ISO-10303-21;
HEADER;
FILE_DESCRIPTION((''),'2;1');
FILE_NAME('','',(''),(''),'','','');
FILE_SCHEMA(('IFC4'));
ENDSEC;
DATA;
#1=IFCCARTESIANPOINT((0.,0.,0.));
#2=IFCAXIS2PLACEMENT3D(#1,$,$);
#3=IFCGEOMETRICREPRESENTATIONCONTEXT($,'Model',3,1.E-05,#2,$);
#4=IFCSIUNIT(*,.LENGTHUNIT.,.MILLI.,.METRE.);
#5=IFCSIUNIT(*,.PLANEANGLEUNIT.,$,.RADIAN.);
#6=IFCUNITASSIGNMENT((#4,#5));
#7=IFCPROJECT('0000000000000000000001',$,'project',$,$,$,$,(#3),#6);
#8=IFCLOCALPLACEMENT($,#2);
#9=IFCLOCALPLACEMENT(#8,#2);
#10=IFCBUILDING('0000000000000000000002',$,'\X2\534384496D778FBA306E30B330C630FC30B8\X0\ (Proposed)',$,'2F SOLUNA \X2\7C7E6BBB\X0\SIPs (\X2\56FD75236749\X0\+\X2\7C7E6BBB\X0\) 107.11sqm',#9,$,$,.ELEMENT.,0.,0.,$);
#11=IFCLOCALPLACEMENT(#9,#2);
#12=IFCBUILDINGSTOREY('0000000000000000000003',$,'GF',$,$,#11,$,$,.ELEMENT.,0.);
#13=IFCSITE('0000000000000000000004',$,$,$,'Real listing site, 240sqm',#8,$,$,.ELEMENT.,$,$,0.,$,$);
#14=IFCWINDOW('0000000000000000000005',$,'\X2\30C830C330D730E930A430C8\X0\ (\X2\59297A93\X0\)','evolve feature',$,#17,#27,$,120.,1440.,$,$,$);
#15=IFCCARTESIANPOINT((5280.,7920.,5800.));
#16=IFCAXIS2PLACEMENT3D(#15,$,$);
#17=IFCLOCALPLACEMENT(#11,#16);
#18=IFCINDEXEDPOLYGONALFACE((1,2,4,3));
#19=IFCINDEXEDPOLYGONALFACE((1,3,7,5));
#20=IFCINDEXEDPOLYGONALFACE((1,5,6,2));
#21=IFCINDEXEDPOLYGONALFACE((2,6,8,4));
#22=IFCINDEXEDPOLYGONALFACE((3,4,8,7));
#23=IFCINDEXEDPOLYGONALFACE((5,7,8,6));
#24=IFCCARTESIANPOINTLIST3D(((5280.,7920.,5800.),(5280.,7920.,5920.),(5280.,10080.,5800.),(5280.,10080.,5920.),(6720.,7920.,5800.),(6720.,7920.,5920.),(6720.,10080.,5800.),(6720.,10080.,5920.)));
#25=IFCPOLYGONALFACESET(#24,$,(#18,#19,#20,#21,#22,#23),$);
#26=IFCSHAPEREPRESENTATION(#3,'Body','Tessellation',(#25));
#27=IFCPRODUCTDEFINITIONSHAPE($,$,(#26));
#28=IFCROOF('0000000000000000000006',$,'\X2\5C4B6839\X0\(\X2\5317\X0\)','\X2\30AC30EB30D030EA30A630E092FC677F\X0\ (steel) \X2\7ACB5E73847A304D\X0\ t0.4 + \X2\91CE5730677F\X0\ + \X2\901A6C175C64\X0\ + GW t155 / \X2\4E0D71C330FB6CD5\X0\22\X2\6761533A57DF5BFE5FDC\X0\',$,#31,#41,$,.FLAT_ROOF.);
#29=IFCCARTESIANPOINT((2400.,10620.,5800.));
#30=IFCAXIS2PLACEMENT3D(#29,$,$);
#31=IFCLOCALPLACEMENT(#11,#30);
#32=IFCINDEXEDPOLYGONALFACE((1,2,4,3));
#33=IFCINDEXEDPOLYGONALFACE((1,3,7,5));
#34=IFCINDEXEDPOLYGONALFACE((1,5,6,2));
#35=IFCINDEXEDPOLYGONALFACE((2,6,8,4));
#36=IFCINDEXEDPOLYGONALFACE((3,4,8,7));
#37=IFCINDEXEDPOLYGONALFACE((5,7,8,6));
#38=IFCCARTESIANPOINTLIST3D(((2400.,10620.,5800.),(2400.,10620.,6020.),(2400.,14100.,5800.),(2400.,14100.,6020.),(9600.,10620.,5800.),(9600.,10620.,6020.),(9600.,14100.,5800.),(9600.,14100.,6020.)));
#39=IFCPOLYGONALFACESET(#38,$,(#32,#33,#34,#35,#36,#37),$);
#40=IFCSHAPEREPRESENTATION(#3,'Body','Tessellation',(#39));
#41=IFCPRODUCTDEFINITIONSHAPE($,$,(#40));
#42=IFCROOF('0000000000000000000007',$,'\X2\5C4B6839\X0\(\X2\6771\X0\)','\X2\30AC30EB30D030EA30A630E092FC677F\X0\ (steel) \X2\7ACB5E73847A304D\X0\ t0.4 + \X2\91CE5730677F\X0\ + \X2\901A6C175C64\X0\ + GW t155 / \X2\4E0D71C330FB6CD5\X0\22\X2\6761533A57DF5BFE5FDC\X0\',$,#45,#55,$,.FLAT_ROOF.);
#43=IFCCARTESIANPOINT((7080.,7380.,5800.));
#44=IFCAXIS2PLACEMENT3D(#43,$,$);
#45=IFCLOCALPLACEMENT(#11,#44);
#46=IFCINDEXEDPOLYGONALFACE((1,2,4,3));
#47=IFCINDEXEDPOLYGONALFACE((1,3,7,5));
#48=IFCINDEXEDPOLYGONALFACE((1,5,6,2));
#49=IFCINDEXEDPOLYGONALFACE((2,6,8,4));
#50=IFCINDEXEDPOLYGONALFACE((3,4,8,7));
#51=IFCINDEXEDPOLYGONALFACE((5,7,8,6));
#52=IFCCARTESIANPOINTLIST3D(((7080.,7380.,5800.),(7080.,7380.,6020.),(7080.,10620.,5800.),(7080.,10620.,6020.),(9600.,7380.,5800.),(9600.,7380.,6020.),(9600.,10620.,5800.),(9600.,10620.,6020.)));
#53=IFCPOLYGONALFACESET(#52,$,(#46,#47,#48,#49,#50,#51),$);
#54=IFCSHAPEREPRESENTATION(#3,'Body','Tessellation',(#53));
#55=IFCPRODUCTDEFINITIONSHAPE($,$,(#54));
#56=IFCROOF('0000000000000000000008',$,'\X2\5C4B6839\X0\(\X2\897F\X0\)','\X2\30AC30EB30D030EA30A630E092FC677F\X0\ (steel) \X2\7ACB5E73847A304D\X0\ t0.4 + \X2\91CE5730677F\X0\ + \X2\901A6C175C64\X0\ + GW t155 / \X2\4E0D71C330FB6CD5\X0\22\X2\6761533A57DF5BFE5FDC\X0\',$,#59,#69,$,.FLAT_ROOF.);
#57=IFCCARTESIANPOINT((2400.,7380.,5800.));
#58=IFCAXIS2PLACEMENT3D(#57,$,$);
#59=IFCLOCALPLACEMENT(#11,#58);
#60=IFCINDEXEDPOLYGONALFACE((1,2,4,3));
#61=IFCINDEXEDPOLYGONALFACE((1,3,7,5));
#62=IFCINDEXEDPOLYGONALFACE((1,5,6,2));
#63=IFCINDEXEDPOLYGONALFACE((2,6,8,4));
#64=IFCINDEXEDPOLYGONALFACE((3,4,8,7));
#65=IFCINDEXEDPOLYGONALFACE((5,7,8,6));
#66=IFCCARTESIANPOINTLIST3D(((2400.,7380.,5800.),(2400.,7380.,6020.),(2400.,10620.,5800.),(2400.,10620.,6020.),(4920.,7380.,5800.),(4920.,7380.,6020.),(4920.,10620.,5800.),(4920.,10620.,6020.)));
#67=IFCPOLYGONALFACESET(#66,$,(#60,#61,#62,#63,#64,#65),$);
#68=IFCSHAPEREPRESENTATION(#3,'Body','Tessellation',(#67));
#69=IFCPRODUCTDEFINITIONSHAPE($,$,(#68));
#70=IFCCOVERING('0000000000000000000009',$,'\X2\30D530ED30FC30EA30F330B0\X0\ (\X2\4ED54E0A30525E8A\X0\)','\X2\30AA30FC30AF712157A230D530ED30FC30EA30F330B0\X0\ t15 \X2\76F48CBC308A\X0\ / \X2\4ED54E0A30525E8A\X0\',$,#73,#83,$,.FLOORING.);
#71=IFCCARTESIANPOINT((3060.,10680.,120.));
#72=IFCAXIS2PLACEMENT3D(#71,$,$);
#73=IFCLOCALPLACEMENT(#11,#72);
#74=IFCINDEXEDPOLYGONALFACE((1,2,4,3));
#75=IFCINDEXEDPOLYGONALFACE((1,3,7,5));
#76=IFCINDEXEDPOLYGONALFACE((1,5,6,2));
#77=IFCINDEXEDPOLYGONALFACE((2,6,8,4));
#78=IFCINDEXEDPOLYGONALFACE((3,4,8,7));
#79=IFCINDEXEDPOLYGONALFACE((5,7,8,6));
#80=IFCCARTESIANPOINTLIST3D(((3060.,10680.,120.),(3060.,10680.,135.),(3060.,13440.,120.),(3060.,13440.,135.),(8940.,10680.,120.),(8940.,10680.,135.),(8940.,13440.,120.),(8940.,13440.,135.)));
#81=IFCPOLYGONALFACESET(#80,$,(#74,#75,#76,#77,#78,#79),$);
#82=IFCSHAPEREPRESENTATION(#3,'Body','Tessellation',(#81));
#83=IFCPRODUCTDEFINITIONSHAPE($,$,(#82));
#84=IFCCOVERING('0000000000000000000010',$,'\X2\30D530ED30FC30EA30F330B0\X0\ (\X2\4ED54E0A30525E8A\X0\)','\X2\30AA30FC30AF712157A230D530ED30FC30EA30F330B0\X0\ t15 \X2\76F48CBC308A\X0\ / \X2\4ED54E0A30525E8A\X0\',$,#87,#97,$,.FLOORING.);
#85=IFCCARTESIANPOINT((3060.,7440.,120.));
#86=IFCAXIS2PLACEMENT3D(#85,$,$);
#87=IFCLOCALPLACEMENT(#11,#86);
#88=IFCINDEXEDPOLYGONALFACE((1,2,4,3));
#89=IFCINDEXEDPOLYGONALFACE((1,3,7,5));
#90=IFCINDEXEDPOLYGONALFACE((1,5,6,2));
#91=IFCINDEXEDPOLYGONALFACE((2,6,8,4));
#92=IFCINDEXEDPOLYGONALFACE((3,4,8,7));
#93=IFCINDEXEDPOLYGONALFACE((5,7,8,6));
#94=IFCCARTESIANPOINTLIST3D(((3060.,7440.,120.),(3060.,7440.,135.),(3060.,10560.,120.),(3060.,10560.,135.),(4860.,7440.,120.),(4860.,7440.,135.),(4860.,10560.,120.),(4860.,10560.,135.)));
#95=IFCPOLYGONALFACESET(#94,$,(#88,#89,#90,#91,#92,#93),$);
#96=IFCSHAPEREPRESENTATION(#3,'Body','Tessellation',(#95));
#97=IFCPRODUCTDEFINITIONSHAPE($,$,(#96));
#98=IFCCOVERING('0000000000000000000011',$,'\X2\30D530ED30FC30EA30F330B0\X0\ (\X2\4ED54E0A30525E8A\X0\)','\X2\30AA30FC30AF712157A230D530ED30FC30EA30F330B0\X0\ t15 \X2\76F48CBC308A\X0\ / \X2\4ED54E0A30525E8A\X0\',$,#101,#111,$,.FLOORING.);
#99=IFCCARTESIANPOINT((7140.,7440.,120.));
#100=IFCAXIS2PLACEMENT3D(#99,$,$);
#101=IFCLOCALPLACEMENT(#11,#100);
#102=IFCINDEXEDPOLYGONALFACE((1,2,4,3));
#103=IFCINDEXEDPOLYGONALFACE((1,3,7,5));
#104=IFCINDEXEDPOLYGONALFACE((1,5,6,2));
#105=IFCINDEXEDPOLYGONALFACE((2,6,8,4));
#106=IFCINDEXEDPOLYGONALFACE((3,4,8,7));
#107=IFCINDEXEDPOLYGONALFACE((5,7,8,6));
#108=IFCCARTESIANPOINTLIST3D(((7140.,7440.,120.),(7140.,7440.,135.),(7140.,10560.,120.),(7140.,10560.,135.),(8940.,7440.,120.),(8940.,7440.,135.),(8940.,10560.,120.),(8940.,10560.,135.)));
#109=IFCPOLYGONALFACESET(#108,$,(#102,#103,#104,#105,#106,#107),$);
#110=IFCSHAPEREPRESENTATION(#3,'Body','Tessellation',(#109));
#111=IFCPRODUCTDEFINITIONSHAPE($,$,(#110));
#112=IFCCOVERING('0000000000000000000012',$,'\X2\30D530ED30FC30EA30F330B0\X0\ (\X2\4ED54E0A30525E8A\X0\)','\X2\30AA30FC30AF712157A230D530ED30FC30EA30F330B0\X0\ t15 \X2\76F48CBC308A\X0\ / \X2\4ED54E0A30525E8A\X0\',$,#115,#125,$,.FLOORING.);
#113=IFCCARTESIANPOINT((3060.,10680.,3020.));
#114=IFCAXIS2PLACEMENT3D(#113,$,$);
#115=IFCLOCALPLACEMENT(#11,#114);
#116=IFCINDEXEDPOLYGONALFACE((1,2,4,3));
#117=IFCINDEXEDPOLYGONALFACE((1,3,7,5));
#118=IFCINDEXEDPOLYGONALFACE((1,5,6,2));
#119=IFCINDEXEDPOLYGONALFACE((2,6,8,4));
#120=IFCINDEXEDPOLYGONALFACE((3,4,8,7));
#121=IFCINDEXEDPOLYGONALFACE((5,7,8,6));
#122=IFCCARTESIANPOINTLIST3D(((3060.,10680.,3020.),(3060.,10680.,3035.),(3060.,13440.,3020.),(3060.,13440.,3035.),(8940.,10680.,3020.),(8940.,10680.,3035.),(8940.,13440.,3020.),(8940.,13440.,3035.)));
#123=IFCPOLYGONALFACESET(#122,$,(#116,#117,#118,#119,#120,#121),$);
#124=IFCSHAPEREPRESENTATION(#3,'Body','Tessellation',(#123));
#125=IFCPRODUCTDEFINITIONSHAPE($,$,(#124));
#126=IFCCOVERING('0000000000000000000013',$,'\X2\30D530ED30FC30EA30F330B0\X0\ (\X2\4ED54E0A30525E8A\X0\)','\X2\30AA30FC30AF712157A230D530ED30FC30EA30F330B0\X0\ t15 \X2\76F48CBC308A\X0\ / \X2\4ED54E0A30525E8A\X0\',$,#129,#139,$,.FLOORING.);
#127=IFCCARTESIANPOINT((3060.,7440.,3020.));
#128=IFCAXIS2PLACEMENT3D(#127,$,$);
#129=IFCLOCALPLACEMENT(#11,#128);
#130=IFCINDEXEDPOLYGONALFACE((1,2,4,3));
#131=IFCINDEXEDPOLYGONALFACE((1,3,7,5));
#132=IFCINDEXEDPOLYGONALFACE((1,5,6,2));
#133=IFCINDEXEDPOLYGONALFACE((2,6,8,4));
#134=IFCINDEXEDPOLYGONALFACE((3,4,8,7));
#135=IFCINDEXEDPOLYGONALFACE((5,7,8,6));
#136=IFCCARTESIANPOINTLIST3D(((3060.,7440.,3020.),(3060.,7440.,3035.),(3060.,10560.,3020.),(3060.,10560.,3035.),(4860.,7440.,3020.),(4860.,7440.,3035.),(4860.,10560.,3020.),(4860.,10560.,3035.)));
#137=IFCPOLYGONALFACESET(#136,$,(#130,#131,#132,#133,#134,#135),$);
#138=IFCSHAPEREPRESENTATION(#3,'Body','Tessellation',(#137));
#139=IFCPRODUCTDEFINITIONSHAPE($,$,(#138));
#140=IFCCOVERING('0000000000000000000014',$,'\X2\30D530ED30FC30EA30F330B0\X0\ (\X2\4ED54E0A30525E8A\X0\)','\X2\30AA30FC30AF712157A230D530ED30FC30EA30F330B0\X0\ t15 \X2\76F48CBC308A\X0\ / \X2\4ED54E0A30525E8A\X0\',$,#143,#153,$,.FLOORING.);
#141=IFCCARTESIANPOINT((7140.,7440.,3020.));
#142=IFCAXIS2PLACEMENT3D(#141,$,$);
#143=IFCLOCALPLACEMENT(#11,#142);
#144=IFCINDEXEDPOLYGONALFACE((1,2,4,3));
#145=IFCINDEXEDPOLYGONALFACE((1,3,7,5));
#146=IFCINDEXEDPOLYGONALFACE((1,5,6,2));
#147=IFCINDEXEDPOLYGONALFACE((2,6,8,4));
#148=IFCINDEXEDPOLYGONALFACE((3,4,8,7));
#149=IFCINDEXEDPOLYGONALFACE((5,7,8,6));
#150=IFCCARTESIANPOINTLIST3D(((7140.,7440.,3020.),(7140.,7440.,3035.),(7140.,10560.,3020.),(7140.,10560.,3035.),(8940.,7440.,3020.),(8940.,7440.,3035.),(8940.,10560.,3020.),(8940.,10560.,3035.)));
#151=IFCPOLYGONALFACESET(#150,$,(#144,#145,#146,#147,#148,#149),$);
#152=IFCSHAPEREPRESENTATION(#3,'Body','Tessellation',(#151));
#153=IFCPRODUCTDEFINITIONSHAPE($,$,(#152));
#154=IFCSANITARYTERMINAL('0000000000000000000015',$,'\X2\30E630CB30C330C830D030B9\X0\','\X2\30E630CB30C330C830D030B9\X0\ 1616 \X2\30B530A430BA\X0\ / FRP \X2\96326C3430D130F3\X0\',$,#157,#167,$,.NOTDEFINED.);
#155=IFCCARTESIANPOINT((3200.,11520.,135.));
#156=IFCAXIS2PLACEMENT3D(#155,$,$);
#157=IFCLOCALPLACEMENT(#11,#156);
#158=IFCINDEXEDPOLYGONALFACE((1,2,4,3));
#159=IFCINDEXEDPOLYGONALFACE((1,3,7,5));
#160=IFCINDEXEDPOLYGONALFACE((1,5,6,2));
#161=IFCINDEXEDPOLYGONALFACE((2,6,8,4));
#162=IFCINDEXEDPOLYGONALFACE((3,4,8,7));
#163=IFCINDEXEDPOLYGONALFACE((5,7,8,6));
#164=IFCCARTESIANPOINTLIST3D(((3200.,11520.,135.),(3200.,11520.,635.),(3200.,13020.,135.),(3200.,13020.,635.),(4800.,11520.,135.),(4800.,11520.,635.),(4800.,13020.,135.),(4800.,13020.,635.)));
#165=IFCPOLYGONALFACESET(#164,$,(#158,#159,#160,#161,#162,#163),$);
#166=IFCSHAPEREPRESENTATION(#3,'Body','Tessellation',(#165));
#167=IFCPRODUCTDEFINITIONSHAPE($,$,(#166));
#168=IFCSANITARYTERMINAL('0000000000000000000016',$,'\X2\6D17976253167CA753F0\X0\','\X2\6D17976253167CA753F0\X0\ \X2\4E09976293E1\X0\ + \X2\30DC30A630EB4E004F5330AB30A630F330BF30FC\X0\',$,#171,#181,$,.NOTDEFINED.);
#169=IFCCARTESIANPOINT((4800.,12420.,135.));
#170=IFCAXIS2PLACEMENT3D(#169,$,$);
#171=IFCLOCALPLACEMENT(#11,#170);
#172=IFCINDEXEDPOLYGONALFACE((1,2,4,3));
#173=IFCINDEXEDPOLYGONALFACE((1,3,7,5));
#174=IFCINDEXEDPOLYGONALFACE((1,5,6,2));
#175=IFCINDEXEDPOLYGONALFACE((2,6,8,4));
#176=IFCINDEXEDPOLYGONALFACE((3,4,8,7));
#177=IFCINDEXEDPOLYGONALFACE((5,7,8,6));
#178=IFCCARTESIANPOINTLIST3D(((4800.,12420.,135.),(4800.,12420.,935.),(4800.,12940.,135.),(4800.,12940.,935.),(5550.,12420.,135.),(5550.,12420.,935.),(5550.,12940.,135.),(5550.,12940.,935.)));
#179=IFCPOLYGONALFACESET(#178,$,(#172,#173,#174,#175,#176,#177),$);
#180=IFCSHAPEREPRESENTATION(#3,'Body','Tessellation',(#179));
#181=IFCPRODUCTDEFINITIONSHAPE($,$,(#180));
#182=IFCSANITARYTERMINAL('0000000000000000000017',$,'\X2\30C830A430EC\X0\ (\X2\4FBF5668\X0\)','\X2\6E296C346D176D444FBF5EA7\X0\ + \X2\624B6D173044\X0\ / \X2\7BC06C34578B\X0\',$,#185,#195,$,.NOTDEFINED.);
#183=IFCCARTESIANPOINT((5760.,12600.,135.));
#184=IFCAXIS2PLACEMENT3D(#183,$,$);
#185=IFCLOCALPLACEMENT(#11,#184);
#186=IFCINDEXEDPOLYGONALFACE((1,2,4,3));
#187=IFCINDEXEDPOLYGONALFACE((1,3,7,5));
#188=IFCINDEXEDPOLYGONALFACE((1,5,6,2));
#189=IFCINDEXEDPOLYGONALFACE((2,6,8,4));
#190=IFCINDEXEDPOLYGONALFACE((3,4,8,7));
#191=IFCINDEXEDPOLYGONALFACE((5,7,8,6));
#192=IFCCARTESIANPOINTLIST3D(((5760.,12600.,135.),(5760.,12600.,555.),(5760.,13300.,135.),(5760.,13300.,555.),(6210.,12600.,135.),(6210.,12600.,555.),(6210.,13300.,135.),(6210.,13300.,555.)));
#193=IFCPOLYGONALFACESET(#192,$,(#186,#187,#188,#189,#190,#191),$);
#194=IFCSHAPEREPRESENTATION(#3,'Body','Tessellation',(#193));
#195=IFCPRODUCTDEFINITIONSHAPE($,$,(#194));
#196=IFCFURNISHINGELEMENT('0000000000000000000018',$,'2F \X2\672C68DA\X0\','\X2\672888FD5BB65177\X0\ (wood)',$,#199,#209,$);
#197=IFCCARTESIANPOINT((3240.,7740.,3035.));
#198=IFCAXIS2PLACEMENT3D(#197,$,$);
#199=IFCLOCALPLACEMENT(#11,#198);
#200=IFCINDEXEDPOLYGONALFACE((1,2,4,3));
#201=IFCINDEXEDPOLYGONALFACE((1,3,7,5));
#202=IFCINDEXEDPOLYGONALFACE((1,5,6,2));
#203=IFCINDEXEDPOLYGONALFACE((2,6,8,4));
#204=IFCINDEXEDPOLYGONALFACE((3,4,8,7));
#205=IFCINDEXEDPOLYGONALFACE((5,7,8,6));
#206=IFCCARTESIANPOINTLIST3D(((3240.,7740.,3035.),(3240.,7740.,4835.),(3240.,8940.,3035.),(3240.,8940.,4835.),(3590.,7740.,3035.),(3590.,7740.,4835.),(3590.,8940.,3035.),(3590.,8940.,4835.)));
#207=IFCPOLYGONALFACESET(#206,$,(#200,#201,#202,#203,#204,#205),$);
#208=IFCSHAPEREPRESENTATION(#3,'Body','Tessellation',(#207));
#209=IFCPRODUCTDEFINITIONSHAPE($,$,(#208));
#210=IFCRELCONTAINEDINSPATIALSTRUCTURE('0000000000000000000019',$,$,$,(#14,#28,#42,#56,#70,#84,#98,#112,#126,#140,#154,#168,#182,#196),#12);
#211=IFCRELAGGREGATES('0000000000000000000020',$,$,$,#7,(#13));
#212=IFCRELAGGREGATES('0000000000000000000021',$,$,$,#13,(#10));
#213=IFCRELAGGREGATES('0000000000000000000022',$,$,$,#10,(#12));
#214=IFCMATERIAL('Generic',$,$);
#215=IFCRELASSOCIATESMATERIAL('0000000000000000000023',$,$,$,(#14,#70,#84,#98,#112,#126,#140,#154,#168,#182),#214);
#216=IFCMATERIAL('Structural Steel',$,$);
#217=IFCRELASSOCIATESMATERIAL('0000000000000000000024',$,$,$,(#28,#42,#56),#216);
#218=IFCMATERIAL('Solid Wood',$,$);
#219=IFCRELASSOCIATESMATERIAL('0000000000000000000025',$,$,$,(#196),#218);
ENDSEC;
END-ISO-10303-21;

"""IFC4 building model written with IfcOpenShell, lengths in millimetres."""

from ifc_helpers import new_model, si_unit, frame, frame_2d, origin, place, context, project, spatial, rectangle, extrude, material, element, save


model = new_model("IFC4")

# Units and contexts
model_context = context("Model", 3, precision=1e-05, world=origin())
ifc_project = project(units=[si_unit("LENGTHUNIT", "METRE", prefix="MILLI"), si_unit("PLANEANGLEUNIT", "RADIAN")], contexts=[model_context])

# Site, building, storey
site_placement = place(None, origin())
site = spatial("IfcSite", under=ifc_project, at=site_placement, ObjectType="Real listing site, 240sqm", CompositionType="ELEMENT", RefElevation=0.0)
building_placement = place(site_placement, origin())
building = spatial("IfcBuilding", under=site, at=building_placement, Name="千葉海辺のコテージ (Proposed)", ObjectType="2F SOLUNA 籾殻SIPs (国産杉+籾殻) 107.11sqm", CompositionType="ELEMENT", ElevationOfRefHeight=0.0, ElevationOfTerrain=0.0)
storey_placement = place(building_placement, origin())
storey = spatial("IfcBuildingStorey", under=building, at=storey_placement, Name="GF", CompositionType="ELEMENT", Elevation=0.0)

# Shared definitions
ifc_material_1 = material(Name="Solid Wood")

# Window
ifc_material_2 = material(Name="Generic")
window_1_placement = place(storey_placement, frame((5280.0, 7920.0, 5800.0)))
element("IfcWindow", 1, at=window_1_placement, inside=storey, material=ifc_material_2, Name="トップライト (天窓)", Description="evolve feature", OverallHeight=120.0, OverallWidth=1440.0, context=model_context, shape_type="SweptSolid", body=[
    extrude(rectangle(XDim=1440.0, YDim=2160.0, at=frame_2d((720.0, 1080.0))), frame((5280.0, 7920.0, 5800.0)), (0.0, 0.0, 1.0), 120.0),
])

# Roofs
ifc_material_3 = material(Name="Structural Steel")
roof_1_placement = place(storey_placement, frame((2400.0, 10620.0, 5800.0)))
element("IfcRoof", 2, at=roof_1_placement, inside=storey, material=ifc_material_3, Name="屋根(北)", Description="ガルバリウム鋼板 (steel) 立平葺き t0.4 + 野地板 + 通気層 + GW t155 / 不燃・法22条区域対応", PredefinedType="FLAT_ROOF", context=model_context, shape_type="SweptSolid", body=[
    extrude(rectangle(XDim=7200.0, YDim=3480.0, at=frame_2d((3600.0, 1740.0))), frame((2400.0, 10620.0, 5800.0)), (0.0, 0.0, 1.0), 220.0),
])
roof_2_placement = place(storey_placement, frame((7080.0, 7380.0, 5800.0)))
element("IfcRoof", 3, at=roof_2_placement, inside=storey, material=ifc_material_3, Name="屋根(東)", Description="ガルバリウム鋼板 (steel) 立平葺き t0.4 + 野地板 + 通気層 + GW t155 / 不燃・法22条区域対応", PredefinedType="FLAT_ROOF", context=model_context, shape_type="SweptSolid", body=[
    extrude(rectangle(XDim=2520.0, YDim=3240.0, at=frame_2d((1260.0, 1620.0))), frame((7080.0, 7380.0, 5800.0)), (0.0, 0.0, 1.0), 220.0),
])
roof_3_placement = place(storey_placement, frame((2400.0, 7380.0, 5800.0)))
element("IfcRoof", 4, at=roof_3_placement, inside=storey, material=ifc_material_3, Name="屋根(西)", Description="ガルバリウム鋼板 (steel) 立平葺き t0.4 + 野地板 + 通気層 + GW t155 / 不燃・法22条区域対応", PredefinedType="FLAT_ROOF", context=model_context, shape_type="SweptSolid", body=[
    extrude(rectangle(XDim=2520.0, YDim=3240.0, at=frame_2d((1260.0, 1620.0))), frame((2400.0, 7380.0, 5800.0)), (0.0, 0.0, 1.0), 220.0),
])

# Coverings
covering_1_placement = place(storey_placement, frame((3060.0, 10680.0, 120.0)))
element("IfcCovering", 5, at=covering_1_placement, inside=storey, material=ifc_material_2, Name="フローリング (仕上げ床)", Description="オーク無垢フローリング t15 直貼り / 仕上げ床", PredefinedType="FLOORING", context=model_context, shape_type="SweptSolid", body=[
    extrude(rectangle(XDim=5880.0, YDim=2760.0, at=frame_2d((2940.0, 1380.0))), frame((3060.0, 10680.0, 120.0)), (0.0, 0.0, 1.0), 15.0),
])
covering_2_placement = place(storey_placement, frame((3060.0, 7440.0, 120.0)))
element("IfcCovering", 6, at=covering_2_placement, inside=storey, material=ifc_material_2, Name="フローリング (仕上げ床)", Description="オーク無垢フローリング t15 直貼り / 仕上げ床", PredefinedType="FLOORING", context=model_context, shape_type="SweptSolid", body=[
    extrude(rectangle(XDim=1800.0, YDim=3120.0, at=frame_2d((900.0, 1560.0))), frame((3060.0, 7440.0, 120.0)), (0.0, 0.0, 1.0), 15.0),
])
covering_3_placement = place(storey_placement, frame((7140.0, 7440.0, 120.0)))
element("IfcCovering", 7, at=covering_3_placement, inside=storey, material=ifc_material_2, Name="フローリング (仕上げ床)", Description="オーク無垢フローリング t15 直貼り / 仕上げ床", PredefinedType="FLOORING", context=model_context, shape_type="SweptSolid", body=[
    extrude(rectangle(XDim=1800.0, YDim=3120.0, at=frame_2d((900.0, 1560.0))), frame((7140.0, 7440.0, 120.0)), (0.0, 0.0, 1.0), 15.0),
])
covering_4_placement = place(storey_placement, frame((3060.0, 10680.0, 3020.0)))
element("IfcCovering", 8, at=covering_4_placement, inside=storey, material=ifc_material_2, Name="フローリング (仕上げ床)", Description="オーク無垢フローリング t15 直貼り / 仕上げ床", PredefinedType="FLOORING", context=model_context, shape_type="SweptSolid", body=[
    extrude(rectangle(XDim=5880.0, YDim=2760.0, at=frame_2d((2940.0, 1380.0))), frame((3060.0, 10680.0, 3020.0)), (0.0, 0.0, 1.0), 15.0),
])
covering_5_placement = place(storey_placement, frame((3060.0, 7440.0, 3020.0)))
element("IfcCovering", 9, at=covering_5_placement, inside=storey, material=ifc_material_2, Name="フローリング (仕上げ床)", Description="オーク無垢フローリング t15 直貼り / 仕上げ床", PredefinedType="FLOORING", context=model_context, shape_type="SweptSolid", body=[
    extrude(rectangle(XDim=1800.0, YDim=3120.0, at=frame_2d((900.0, 1560.0))), frame((3060.0, 7440.0, 3020.0)), (0.0, 0.0, 1.0), 15.0),
])
covering_6_placement = place(storey_placement, frame((7140.0, 7440.0, 3020.0)))
element("IfcCovering", 10, at=covering_6_placement, inside=storey, material=ifc_material_2, Name="フローリング (仕上げ床)", Description="オーク無垢フローリング t15 直貼り / 仕上げ床", PredefinedType="FLOORING", context=model_context, shape_type="SweptSolid", body=[
    extrude(rectangle(XDim=1800.0, YDim=3120.0, at=frame_2d((900.0, 1560.0))), frame((7140.0, 7440.0, 3020.0)), (0.0, 0.0, 1.0), 15.0),
])

# Sanitary terminals
sanitary_terminal_1_placement = place(storey_placement, frame((3200.0, 11520.0, 135.0)))
element("IfcSanitaryTerminal", 11, at=sanitary_terminal_1_placement, inside=storey, material=ifc_material_2, Name="ユニットバス", Description="ユニットバス 1616 サイズ / FRP 防水パン", PredefinedType="NOTDEFINED", context=model_context, shape_type="SweptSolid", body=[
    extrude(rectangle(XDim=1600.0, YDim=1500.0, at=frame_2d((800.0, 750.0))), frame((3200.0, 11520.0, 135.0)), (0.0, 0.0, 1.0), 500.0),
])
sanitary_terminal_2_placement = place(storey_placement, frame((4800.0, 12420.0, 135.0)))
element("IfcSanitaryTerminal", 12, at=sanitary_terminal_2_placement, inside=storey, material=ifc_material_2, Name="洗面化粧台", Description="洗面化粧台 三面鏡 + ボウル一体カウンター", PredefinedType="NOTDEFINED", context=model_context, shape_type="SweptSolid", body=[
    extrude(rectangle(XDim=750.0, YDim=520.0, at=frame_2d((375.0, 260.0))), frame((4800.0, 12420.0, 135.0)), (0.0, 0.0, 1.0), 800.0),
])
sanitary_terminal_3_placement = place(storey_placement, frame((5760.0, 12600.0, 135.0)))
element("IfcSanitaryTerminal", 13, at=sanitary_terminal_3_placement, inside=storey, material=ifc_material_2, Name="トイレ (便器)", Description="温水洗浄便座 + 手洗い / 節水型", PredefinedType="NOTDEFINED", context=model_context, shape_type="SweptSolid", body=[
    extrude(rectangle(XDim=450.0, YDim=700.0, at=frame_2d((225.0, 350.0))), frame((5760.0, 12600.0, 135.0)), (0.0, 0.0, 1.0), 420.0),
])

# Furnishing element
furnishing_placement = place(storey_placement, frame((3240.0, 7740.0, 3035.0)))
element("IfcFurnishingElement", 14, at=furnishing_placement, inside=storey, material=ifc_material_1, Name="2F 本棚", Description="木製家具 (wood)", context=model_context, shape_type="SweptSolid", body=[
    extrude(rectangle(XDim=350.0, YDim=1200.0, at=frame_2d((175.0, 600.0))), frame((3240.0, 7740.0, 3035.0)), (0.0, 0.0, 1.0), 1800.0),
])

save(model, "model.ifc")
